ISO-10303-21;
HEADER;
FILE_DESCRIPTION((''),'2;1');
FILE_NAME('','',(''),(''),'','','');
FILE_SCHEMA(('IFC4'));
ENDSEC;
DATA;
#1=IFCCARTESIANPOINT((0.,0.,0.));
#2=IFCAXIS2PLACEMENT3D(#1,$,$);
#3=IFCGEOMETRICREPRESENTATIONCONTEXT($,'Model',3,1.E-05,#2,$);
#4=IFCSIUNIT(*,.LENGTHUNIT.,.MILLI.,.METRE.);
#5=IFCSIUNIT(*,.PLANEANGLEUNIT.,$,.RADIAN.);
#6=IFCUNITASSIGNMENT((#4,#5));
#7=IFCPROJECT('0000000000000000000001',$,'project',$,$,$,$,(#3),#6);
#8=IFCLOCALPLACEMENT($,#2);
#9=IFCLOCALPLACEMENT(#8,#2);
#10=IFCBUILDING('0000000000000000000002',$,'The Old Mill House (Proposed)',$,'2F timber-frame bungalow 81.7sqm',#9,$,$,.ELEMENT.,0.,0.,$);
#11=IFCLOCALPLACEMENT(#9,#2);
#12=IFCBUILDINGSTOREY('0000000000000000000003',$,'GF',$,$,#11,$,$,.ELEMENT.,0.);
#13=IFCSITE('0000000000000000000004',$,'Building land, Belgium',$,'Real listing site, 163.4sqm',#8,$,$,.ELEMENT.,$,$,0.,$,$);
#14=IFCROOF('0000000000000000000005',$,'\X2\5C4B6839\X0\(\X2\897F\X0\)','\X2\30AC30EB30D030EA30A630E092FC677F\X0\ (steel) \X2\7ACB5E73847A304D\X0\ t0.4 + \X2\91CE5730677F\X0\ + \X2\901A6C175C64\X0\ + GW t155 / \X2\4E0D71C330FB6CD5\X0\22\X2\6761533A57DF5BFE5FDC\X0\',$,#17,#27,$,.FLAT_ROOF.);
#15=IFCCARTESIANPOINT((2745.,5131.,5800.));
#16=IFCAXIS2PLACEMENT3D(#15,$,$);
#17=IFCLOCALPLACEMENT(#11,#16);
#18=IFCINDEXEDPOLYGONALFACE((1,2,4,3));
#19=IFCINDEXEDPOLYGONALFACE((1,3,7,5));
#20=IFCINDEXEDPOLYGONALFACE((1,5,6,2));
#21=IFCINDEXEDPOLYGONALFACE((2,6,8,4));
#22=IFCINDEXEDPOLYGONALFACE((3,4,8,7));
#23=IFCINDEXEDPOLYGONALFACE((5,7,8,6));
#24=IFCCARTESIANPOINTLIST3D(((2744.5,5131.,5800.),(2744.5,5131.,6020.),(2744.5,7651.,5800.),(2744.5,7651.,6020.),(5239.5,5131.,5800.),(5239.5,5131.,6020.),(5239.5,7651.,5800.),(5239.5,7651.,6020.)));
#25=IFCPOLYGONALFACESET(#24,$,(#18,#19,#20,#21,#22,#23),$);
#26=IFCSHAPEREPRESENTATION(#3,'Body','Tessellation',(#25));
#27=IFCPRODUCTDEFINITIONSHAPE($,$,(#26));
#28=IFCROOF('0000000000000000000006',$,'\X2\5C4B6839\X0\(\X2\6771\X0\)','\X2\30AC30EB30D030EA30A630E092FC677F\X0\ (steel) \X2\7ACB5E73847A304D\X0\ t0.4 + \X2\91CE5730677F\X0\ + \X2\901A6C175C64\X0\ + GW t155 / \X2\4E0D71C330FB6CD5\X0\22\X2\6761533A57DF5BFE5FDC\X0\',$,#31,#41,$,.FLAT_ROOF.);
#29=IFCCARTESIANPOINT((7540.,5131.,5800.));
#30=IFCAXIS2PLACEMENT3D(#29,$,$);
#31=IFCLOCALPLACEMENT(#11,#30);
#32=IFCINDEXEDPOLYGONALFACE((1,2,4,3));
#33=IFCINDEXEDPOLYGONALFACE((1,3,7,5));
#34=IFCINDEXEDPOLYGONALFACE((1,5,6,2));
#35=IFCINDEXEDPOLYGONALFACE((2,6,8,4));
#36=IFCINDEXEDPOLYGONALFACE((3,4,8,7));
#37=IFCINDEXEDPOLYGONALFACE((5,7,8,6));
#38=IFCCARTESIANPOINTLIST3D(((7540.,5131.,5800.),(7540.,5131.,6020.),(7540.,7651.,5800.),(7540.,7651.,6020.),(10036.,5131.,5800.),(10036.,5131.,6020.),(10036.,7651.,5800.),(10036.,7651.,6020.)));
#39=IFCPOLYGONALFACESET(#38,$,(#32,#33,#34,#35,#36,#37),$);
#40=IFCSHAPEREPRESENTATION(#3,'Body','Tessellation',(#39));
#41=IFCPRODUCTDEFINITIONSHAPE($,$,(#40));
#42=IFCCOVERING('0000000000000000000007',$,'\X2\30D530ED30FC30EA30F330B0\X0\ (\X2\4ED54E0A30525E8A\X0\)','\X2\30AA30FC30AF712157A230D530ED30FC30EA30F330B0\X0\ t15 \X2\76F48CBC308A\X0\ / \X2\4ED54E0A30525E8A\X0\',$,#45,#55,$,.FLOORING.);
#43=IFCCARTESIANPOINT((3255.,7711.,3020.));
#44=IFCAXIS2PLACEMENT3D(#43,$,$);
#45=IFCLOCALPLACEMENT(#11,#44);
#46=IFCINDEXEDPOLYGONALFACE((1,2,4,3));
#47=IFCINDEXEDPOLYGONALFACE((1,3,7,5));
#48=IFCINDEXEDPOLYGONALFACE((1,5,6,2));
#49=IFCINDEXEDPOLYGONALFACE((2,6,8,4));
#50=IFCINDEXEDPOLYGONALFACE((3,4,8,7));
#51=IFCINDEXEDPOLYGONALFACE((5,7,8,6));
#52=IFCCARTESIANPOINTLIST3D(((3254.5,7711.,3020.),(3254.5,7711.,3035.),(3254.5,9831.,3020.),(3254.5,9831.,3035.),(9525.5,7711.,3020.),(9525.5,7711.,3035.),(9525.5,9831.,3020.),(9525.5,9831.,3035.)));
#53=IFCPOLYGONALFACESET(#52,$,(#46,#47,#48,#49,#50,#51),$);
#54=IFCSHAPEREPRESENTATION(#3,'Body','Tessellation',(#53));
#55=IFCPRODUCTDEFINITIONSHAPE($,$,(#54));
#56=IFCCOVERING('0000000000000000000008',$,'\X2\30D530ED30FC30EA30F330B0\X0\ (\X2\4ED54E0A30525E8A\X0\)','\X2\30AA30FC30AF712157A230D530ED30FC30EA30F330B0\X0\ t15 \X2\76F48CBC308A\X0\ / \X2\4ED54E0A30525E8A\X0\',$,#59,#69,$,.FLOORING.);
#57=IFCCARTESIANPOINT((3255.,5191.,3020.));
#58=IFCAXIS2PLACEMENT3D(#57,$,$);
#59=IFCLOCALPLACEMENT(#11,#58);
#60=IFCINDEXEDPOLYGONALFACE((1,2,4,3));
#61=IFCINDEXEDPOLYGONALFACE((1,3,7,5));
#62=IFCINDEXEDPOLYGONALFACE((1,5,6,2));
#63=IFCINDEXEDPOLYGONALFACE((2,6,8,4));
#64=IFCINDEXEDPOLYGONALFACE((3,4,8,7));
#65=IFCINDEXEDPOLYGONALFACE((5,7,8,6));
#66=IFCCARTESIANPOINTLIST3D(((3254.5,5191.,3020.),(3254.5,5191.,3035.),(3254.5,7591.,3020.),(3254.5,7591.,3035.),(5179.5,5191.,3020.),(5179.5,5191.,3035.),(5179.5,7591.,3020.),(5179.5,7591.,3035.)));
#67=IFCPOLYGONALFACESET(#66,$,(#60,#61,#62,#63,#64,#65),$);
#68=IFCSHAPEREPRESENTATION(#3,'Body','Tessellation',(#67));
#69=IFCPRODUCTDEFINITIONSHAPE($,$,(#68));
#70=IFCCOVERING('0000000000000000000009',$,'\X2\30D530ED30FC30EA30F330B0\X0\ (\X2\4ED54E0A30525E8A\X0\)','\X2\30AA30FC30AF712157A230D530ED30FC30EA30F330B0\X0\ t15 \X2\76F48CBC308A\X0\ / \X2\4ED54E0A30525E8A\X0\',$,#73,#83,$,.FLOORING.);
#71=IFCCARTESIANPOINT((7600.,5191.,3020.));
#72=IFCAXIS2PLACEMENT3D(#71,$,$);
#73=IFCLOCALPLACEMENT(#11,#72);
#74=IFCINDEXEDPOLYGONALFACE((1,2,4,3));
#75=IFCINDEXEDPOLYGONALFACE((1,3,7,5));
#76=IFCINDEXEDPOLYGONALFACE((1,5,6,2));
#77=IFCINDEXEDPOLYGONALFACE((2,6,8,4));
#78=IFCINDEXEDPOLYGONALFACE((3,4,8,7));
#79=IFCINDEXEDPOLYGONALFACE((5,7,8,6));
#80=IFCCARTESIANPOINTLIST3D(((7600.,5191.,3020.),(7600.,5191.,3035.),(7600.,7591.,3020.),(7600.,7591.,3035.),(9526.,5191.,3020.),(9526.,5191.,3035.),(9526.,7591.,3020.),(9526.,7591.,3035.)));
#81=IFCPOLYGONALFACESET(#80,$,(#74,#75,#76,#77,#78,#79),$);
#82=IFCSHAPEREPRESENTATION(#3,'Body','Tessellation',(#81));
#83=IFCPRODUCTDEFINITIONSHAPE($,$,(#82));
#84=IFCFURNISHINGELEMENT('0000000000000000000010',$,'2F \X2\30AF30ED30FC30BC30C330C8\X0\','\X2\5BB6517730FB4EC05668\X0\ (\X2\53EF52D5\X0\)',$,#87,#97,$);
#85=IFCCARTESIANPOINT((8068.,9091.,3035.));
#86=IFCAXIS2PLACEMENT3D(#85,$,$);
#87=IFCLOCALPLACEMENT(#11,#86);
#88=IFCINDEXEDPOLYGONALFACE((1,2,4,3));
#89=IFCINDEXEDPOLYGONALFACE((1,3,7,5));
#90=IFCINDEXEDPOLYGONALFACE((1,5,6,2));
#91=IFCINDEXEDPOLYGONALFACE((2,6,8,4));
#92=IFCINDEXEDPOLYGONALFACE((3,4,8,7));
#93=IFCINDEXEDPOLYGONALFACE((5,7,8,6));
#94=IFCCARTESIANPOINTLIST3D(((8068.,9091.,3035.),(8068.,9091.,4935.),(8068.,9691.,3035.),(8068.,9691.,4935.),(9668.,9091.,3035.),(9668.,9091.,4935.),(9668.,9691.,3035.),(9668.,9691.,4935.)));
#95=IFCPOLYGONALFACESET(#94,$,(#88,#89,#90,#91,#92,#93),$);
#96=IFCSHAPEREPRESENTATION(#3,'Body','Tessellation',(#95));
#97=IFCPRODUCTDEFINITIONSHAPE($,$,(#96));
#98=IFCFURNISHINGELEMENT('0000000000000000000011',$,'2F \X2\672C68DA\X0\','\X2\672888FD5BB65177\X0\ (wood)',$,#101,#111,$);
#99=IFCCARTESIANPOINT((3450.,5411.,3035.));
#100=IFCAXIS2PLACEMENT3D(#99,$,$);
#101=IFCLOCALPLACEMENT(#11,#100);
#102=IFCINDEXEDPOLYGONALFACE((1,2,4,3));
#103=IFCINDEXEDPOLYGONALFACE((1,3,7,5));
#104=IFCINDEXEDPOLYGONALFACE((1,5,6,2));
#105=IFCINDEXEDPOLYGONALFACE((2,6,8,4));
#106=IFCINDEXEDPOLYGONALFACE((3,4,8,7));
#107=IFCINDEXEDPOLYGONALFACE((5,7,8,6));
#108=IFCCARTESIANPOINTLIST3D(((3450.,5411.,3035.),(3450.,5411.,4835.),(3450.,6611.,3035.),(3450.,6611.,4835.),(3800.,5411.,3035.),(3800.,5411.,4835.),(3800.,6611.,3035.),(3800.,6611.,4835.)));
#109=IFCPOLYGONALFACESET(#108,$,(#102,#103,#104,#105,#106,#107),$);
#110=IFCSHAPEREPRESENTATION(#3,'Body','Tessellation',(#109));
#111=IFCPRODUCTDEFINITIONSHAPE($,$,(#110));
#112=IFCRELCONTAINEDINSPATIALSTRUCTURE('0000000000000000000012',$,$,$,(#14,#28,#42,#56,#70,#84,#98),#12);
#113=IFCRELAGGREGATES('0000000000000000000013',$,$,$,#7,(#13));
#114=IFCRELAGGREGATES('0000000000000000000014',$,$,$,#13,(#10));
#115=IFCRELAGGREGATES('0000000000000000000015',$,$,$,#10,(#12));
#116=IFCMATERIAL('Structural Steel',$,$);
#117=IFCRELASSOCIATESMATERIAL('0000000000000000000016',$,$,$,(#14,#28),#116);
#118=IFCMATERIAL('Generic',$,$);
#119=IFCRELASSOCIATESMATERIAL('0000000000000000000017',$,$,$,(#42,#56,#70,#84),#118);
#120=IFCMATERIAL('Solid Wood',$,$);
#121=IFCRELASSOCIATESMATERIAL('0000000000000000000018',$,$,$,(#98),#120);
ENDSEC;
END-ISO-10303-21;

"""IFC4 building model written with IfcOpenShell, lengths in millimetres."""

from ifc_helpers import new_model, si_unit, frame, frame_2d, origin, place, context, project, spatial, rectangle, extrude, material, element, save


model = new_model("IFC4")

# Units and contexts
model_context = context("Model", 3, precision=1e-05, world=origin())
ifc_project = project(units=[si_unit("LENGTHUNIT", "METRE", prefix="MILLI"), si_unit("PLANEANGLEUNIT", "RADIAN")], contexts=[model_context])

# Site, building, storey
site_placement = place(None, origin())
site = spatial("IfcSite", under=ifc_project, at=site_placement, Name="Building land, Belgium", ObjectType="Real listing site, 163.4sqm", CompositionType="ELEMENT", RefElevation=0.0)
building_placement = place(site_placement, origin())
building = spatial("IfcBuilding", under=site, at=building_placement, Name="The Old Mill House (Proposed)", ObjectType="2F timber-frame bungalow 81.7sqm", CompositionType="ELEMENT", ElevationOfRefHeight=0.0, ElevationOfTerrain=0.0)
storey_placement = place(building_placement, origin())
storey = spatial("IfcBuildingStorey", under=building, at=storey_placement, Name="GF", CompositionType="ELEMENT", Elevation=0.0)

# Shared definitions
ifc_material_1 = material(Name="Solid Wood")

# Roofs
ifc_material_2 = material(Name="Structural Steel")
roof_1_placement = place(storey_placement, frame((2745.0, 5131.0, 5800.0)))
element("IfcRoof", 1, at=roof_1_placement, inside=storey, material=ifc_material_2, Name="屋根(西)", Description="ガルバリウム鋼板 (steel) 立平葺き t0.4 + 野地板 + 通気層 + GW t155 / 不燃・法22条区域対応", PredefinedType="FLAT_ROOF", context=model_context, shape_type="SweptSolid", body=[
    extrude(rectangle(XDim=2495.0, YDim=2520.0, at=frame_2d((1247.0, 1260.0))), frame((2745.0, 5131.0, 5800.0)), (0.0, 0.0, 1.0), 220.0),
])
roof_2_placement = place(storey_placement, frame((7540.0, 5131.0, 5800.0)))
element("IfcRoof", 2, at=roof_2_placement, inside=storey, material=ifc_material_2, Name="屋根(東)", Description="ガルバリウム鋼板 (steel) 立平葺き t0.4 + 野地板 + 通気層 + GW t155 / 不燃・法22条区域対応", PredefinedType="FLAT_ROOF", context=model_context, shape_type="SweptSolid", body=[
    extrude(rectangle(XDim=2496.0, YDim=2520.0, at=frame_2d((1248.0, 1260.0))), frame((7540.0, 5131.0, 5800.0)), (0.0, 0.0, 1.0), 220.0),
])

# Coverings
ifc_material_3 = material(Name="Generic")
covering_1_placement = place(storey_placement, frame((3255.0, 7711.0, 3020.0)))
element("IfcCovering", 3, at=covering_1_placement, inside=storey, material=ifc_material_3, Name="フローリング (仕上げ床)", Description="オーク無垢フローリング t15 直貼り / 仕上げ床", PredefinedType="FLOORING", context=model_context, shape_type="SweptSolid", body=[
    extrude(rectangle(XDim=6271.0, YDim=2120.0, at=frame_2d((3135.0, 1060.0))), frame((3255.0, 7711.0, 3020.0)), (0.0, 0.0, 1.0), 15.0),
])
covering_2_placement = place(storey_placement, frame((3255.0, 5191.0, 3020.0)))
element("IfcCovering", 4, at=covering_2_placement, inside=storey, material=ifc_material_3, Name="フローリング (仕上げ床)", Description="オーク無垢フローリング t15 直貼り / 仕上げ床", PredefinedType="FLOORING", context=model_context, shape_type="SweptSolid", body=[
    extrude(rectangle(XDim=1925.0, YDim=2400.0, at=frame_2d((962.0, 1200.0))), frame((3255.0, 5191.0, 3020.0)), (0.0, 0.0, 1.0), 15.0),
])
covering_3_placement = place(storey_placement, frame((7600.0, 5191.0, 3020.0)))
element("IfcCovering", 5, at=covering_3_placement, inside=storey, material=ifc_material_3, Name="フローリング (仕上げ床)", Description="オーク無垢フローリング t15 直貼り / 仕上げ床", PredefinedType="FLOORING", context=model_context, shape_type="SweptSolid", body=[
    extrude(rectangle(XDim=1926.0, YDim=2400.0, at=frame_2d((963.0, 1200.0))), frame((7600.0, 5191.0, 3020.0)), (0.0, 0.0, 1.0), 15.0),
])

# Furnishing elements
furnishing_1_placement = place(storey_placement, frame((8068.0, 9091.0, 3035.0)))
element("IfcFurnishingElement", 6, at=furnishing_1_placement, inside=storey, material=ifc_material_3, Name="2F クローゼット", Description="家具・什器 (可動)", context=model_context, shape_type="SweptSolid", body=[
    extrude(rectangle(XDim=1600.0, YDim=600.0, at=frame_2d((800.0, 300.0))), frame((8068.0, 9091.0, 3035.0)), (0.0, 0.0, 1.0), 1900.0),
])
furnishing_2_placement = place(storey_placement, frame((3450.0, 5411.0, 3035.0)))
element("IfcFurnishingElement", 7, at=furnishing_2_placement, inside=storey, material=ifc_material_1, Name="2F 本棚", Description="木製家具 (wood)", context=model_context, shape_type="SweptSolid", body=[
    extrude(rectangle(XDim=350.0, YDim=1200.0, at=frame_2d((175.0, 600.0))), frame((3450.0, 5411.0, 3035.0)), (0.0, 0.0, 1.0), 1800.0),
])

save(model, "model.ifc")
